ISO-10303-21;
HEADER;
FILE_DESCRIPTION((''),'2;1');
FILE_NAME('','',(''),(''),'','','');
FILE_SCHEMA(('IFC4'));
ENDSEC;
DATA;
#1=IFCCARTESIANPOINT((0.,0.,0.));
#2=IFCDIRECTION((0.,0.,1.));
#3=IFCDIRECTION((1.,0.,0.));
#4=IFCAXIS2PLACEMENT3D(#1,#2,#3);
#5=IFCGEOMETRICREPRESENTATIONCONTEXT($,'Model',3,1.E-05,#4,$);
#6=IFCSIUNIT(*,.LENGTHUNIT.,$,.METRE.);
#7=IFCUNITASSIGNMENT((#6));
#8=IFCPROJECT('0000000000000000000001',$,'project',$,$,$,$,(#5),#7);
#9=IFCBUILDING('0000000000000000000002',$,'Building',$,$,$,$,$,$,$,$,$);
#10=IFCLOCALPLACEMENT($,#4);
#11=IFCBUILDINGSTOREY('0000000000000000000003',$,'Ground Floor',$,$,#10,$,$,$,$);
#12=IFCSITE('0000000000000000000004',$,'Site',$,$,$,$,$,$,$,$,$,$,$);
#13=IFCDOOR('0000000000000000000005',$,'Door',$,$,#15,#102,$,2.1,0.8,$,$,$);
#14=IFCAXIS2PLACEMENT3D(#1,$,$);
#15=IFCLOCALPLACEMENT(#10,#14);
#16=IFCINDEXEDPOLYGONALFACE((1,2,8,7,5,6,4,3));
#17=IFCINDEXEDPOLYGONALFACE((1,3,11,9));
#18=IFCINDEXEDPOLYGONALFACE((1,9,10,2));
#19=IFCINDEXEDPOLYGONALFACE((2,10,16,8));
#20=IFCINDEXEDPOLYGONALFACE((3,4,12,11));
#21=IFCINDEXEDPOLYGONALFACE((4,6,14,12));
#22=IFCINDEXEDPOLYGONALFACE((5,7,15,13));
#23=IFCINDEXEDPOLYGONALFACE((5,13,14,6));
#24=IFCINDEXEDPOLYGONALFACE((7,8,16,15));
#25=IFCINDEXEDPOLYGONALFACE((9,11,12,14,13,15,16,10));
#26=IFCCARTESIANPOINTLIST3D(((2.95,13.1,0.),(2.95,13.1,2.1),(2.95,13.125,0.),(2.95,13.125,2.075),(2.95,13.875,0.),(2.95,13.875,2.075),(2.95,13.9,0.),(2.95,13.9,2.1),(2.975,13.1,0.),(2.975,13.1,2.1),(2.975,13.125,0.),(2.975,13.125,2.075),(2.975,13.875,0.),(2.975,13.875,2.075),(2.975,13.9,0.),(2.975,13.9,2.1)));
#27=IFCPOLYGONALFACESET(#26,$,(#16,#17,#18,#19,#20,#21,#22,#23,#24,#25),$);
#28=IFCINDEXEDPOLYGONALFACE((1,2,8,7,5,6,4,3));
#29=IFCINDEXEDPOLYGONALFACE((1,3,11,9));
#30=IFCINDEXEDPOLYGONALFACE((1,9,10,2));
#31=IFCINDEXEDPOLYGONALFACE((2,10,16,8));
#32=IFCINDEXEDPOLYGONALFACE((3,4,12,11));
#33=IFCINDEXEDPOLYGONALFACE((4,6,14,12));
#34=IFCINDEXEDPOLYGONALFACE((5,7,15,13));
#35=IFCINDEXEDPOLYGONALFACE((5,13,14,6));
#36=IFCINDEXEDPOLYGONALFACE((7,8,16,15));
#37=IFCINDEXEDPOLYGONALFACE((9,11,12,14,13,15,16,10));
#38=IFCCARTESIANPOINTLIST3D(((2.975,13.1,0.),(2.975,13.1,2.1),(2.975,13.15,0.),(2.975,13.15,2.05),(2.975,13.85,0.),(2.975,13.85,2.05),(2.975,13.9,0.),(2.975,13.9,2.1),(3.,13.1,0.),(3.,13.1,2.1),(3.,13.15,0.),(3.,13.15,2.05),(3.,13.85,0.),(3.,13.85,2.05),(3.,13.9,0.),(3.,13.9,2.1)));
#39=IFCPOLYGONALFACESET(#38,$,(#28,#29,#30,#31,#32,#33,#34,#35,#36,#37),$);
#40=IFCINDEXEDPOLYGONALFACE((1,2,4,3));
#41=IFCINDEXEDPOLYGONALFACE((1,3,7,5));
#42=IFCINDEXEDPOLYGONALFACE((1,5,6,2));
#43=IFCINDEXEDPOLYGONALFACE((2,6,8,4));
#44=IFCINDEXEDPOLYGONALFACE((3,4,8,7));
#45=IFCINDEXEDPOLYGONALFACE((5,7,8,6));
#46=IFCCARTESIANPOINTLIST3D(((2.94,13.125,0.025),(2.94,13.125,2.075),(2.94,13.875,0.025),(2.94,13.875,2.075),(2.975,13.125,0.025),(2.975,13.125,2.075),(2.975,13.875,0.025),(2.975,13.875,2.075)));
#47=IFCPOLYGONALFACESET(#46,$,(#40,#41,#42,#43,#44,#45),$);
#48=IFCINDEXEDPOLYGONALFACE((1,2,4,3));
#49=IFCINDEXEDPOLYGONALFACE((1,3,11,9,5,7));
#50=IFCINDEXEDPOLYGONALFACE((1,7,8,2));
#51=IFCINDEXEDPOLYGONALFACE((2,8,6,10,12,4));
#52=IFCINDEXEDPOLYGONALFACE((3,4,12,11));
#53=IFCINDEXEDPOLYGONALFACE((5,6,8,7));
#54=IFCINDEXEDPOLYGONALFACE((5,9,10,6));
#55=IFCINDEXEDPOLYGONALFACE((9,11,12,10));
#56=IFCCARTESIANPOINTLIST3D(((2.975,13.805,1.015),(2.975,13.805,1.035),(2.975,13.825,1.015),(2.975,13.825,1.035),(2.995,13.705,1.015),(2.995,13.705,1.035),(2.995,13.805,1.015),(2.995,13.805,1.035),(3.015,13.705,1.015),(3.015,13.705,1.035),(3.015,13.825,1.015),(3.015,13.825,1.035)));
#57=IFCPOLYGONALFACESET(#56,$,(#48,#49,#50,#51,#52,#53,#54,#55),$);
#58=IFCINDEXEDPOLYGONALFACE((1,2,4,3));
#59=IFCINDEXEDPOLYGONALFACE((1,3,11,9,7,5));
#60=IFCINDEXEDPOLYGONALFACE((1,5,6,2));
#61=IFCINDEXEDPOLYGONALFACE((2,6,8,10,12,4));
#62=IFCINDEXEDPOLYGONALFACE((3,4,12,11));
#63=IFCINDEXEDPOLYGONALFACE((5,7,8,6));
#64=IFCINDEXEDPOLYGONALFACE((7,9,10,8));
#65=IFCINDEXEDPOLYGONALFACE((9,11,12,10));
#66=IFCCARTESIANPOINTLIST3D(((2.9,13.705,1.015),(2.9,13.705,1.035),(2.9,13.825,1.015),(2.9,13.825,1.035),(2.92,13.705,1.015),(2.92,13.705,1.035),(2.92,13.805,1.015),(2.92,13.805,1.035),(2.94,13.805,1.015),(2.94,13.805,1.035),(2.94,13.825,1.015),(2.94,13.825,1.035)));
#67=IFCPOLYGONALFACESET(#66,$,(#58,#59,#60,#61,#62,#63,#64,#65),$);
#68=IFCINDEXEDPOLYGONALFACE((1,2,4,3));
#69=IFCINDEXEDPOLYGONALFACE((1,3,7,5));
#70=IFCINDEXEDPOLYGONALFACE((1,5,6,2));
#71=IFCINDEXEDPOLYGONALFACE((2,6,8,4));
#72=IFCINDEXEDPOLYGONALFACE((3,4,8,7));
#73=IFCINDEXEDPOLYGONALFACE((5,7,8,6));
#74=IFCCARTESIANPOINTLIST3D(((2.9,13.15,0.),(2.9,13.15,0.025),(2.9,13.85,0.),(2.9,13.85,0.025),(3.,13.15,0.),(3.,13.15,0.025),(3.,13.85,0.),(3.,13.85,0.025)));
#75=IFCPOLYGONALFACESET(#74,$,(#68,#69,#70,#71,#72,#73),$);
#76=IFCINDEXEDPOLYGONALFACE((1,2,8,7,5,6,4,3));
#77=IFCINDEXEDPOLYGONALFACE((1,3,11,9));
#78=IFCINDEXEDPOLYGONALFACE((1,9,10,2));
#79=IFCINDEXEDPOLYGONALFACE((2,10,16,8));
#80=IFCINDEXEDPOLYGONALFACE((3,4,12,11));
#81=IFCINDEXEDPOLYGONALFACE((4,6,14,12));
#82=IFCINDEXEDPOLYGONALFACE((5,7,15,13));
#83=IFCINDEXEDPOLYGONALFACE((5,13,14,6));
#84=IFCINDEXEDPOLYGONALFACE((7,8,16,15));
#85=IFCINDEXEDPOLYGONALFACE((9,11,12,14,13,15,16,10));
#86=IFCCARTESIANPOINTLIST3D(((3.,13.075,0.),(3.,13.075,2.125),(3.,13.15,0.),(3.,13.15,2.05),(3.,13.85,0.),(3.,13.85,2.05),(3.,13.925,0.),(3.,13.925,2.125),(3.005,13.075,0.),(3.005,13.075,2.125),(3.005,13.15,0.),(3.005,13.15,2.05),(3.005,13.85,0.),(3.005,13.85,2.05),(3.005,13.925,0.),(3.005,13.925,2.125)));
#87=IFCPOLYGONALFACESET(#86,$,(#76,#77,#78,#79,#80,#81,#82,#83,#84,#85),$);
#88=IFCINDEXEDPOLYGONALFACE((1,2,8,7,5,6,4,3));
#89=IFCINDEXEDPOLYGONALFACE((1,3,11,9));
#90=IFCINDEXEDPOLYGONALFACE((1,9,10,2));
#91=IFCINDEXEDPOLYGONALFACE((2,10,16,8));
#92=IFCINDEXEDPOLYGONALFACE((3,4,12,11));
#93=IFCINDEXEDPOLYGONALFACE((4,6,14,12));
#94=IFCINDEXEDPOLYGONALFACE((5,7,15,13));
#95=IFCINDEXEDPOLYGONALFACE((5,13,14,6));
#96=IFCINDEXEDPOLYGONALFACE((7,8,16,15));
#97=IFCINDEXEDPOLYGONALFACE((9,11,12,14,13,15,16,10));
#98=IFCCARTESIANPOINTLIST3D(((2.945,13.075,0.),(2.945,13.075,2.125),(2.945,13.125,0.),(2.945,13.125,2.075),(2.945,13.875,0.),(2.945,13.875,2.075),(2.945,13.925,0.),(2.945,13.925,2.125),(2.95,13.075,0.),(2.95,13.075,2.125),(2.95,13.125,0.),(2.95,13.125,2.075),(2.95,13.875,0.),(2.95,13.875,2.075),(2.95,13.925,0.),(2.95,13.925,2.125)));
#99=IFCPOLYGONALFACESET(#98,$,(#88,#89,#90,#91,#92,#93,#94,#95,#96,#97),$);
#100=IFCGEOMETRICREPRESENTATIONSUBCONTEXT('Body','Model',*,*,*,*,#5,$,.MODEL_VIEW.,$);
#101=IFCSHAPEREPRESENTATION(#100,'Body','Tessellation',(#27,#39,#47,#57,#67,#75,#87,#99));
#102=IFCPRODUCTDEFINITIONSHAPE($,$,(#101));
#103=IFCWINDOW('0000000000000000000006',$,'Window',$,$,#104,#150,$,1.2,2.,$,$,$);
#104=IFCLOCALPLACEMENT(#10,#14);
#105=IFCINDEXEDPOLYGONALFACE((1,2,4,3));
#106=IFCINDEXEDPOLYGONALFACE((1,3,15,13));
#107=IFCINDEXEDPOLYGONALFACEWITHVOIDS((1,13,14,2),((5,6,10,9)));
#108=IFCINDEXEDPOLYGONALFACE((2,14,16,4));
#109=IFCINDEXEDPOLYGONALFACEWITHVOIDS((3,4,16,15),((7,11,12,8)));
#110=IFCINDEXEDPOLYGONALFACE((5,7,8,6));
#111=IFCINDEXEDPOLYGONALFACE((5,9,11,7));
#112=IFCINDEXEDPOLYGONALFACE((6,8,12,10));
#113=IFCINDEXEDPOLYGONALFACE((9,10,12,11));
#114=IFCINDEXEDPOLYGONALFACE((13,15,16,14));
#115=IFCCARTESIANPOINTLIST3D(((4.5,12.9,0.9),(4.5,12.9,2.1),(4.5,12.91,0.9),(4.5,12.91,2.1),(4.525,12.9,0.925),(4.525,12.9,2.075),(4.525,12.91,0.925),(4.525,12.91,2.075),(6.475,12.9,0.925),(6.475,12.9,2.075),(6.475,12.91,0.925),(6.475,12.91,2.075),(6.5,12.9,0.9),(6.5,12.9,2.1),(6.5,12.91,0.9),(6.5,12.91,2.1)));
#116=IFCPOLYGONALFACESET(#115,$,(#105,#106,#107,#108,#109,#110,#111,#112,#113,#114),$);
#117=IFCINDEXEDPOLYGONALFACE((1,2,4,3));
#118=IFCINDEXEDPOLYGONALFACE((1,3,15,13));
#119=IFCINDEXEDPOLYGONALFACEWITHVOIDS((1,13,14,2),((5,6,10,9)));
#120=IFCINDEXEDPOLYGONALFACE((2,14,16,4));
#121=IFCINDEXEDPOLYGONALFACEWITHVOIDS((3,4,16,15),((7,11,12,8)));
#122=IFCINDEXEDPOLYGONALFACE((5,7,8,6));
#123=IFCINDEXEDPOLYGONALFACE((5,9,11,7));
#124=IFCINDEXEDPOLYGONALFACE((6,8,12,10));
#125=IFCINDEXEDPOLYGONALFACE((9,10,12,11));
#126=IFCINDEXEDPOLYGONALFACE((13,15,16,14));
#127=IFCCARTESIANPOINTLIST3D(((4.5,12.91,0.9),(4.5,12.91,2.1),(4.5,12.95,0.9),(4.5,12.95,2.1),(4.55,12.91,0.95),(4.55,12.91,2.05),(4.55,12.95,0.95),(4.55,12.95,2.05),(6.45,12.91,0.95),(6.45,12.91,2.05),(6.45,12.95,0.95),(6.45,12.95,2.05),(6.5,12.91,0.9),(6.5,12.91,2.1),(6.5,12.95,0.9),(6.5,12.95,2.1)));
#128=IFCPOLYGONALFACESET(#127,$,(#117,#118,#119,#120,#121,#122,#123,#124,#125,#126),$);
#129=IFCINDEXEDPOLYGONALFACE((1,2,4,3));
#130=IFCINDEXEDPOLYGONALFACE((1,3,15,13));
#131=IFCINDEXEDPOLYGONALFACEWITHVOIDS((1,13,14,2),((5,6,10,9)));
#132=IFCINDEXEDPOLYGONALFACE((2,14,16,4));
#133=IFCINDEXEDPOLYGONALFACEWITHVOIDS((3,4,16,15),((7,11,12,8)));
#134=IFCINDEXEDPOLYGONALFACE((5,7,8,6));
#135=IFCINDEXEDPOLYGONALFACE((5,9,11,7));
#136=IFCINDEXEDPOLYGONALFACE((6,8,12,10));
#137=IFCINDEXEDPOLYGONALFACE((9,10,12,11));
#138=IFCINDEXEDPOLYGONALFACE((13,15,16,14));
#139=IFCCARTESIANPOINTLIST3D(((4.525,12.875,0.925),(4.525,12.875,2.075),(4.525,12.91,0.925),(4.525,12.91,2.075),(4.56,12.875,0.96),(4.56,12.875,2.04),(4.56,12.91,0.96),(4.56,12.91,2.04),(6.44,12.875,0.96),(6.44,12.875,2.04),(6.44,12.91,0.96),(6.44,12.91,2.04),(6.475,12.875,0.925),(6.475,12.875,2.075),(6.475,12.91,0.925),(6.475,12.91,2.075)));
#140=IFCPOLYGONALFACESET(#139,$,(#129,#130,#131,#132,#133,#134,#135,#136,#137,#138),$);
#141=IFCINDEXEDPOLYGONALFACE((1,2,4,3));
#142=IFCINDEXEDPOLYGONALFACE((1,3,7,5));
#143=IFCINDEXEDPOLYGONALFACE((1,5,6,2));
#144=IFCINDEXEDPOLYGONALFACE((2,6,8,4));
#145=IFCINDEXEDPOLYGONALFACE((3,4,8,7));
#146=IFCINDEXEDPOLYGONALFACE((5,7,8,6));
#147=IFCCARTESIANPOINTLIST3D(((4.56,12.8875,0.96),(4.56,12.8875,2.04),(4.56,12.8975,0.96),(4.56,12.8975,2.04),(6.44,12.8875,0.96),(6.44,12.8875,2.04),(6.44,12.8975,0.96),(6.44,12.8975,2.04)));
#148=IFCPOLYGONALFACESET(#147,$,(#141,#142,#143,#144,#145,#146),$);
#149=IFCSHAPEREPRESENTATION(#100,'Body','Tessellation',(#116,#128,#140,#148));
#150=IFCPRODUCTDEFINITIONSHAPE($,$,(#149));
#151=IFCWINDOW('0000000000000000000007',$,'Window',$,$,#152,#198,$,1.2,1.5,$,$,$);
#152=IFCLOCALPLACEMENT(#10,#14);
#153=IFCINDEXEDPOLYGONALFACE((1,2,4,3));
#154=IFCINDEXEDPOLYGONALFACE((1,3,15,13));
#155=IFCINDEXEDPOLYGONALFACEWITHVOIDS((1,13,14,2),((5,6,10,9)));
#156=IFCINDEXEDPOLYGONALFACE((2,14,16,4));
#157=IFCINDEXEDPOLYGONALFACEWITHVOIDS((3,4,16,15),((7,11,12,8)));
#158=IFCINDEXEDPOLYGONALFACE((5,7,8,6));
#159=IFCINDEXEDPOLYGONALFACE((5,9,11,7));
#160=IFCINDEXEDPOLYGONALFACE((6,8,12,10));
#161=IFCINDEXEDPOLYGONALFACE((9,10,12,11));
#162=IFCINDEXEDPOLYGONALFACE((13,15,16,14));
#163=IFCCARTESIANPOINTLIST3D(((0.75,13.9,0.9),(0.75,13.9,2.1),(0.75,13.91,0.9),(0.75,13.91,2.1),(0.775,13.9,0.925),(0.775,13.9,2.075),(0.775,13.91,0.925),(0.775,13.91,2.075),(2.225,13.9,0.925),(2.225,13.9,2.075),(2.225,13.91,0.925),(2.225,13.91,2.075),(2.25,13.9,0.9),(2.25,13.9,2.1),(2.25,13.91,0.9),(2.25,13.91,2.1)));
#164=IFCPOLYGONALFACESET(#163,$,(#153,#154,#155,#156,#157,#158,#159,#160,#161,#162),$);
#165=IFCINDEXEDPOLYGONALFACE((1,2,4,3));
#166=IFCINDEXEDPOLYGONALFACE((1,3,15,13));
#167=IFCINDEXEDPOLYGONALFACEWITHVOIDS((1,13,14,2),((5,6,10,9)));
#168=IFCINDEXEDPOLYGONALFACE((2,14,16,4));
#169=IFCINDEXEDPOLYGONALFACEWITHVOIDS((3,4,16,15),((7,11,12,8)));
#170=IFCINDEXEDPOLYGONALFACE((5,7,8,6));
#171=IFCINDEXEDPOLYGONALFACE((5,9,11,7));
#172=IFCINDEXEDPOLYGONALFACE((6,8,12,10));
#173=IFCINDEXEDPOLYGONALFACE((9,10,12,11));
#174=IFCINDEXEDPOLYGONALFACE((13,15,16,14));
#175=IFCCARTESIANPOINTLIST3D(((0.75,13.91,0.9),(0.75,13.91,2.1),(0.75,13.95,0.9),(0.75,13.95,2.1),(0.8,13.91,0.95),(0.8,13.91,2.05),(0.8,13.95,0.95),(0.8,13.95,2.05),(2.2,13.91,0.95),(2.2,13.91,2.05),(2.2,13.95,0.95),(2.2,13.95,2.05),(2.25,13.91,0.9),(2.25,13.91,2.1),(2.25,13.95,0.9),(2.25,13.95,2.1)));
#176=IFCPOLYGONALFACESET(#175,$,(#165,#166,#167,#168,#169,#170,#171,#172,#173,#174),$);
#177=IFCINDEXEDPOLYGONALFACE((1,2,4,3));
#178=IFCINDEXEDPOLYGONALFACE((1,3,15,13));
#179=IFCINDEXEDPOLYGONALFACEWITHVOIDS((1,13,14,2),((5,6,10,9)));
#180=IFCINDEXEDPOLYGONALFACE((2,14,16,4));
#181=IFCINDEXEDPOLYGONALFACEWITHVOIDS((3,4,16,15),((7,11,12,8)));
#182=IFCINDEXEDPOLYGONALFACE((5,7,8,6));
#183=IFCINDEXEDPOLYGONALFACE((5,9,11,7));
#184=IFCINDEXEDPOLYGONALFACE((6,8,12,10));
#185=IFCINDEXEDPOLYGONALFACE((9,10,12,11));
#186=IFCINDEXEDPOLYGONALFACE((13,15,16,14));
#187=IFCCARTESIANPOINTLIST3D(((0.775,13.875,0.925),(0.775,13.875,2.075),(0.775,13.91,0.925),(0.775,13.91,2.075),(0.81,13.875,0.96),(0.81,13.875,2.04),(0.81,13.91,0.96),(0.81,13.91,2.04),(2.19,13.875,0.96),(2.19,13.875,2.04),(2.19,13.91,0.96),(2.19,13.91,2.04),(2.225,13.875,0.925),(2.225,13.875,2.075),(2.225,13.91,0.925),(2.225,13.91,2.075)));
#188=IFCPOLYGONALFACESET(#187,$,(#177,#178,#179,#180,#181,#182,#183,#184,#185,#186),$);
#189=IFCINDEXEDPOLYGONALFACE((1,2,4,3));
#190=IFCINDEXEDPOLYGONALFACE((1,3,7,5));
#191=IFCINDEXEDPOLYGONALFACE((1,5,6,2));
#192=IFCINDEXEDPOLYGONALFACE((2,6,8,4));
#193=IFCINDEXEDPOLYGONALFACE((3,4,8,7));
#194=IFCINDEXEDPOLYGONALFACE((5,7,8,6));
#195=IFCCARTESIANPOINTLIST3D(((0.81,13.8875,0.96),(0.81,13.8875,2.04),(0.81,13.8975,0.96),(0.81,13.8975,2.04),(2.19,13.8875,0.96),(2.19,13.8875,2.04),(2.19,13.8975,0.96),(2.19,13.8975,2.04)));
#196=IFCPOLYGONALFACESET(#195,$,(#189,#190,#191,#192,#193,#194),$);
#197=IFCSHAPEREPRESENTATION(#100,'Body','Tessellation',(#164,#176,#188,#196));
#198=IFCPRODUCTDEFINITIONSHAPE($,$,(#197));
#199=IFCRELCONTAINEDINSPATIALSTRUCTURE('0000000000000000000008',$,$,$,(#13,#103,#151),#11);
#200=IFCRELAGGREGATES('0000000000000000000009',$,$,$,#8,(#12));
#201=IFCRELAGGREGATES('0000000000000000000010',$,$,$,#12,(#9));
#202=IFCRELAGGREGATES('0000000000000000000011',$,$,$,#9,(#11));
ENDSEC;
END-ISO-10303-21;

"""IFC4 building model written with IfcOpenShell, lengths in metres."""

from ifc_helpers import new_model, si_unit, frame, origin_with_axes, place, context, subcontext, project, spatial, line, indexed_curve, outline, extrude, element, save


model = new_model("IFC4")

# Units and contexts
model_context = context("Model", 3, precision=1e-05, world=origin_with_axes())
body_context = subcontext(model_context, "Body", "Model", "MODEL_VIEW")
ifc_project = project(units=[si_unit("LENGTHUNIT", "METRE")], contexts=[model_context])

# Site, building, storey
site = spatial("IfcSite", under=ifc_project, Name="Site")
building = spatial("IfcBuilding", under=site, Name="Building")
storey_placement = place(None, origin_with_axes())
storey = spatial("IfcBuildingStorey", under=building, at=storey_placement, Name="Ground Floor")

# Door
door_1_placement = place(storey_placement, frame((3.0, 13.1, 0.0), z_axis=(0.0, 0.0, 1.0), x_axis=(0.0, 1.0, 0.0)))
element("IfcDoor", 1, at=door_1_placement, inside=storey, Name="Door", OverallHeight=2.1, OverallWidth=0.8, context=body_context, shape_type="SweptSolid", body=[
    extrude(outline(indexed_curve([(0.0, 0.0), (0.0, 2.1), (0.8, 2.1), (0.8, 0.0), (0.775, 0.0), (0.775, 2.075), (0.025, 2.075), (0.025, 0.0)], segments=[line(1, 2, 3, 4, 5, 6, 7, 8, 1)])), frame((0.0, 0.025, 0.0), z_axis=(0.0, -1.0, 0.0), x_axis=(1.0, 0.0, 0.0)), (0.0, 0.0, -1.0), 0.025),
    extrude(outline(indexed_curve([(0.0, 0.0), (0.0, 2.1), (0.8, 2.1), (0.8, 0.0), (0.75, 0.0), (0.75, 2.05), (0.05, 2.05), (0.05, 0.0)], segments=[line(1, 2, 3, 4, 5, 6, 7, 8, 1)])), frame((0.0, 0.0, 0.0), z_axis=(0.0, -1.0, 0.0), x_axis=(1.0, 0.0, 0.0)), (0.0, 0.0, -1.0), 0.025),
    extrude(outline(indexed_curve([(0.0, 0.0), (0.75, 0.0), (0.75, 0.035), (0.0, 0.035)], segments=[line(1, 2, 3, 4, 1)])), frame((0.025, 0.025, 0.025), z_axis=(0.0, 0.0, 1.0), x_axis=(1.0, 0.0, 0.0)), (0.0, 0.0, 1.0), 2.05),
    extrude(outline(indexed_curve([(0.0, 0.0), (0.0, -0.04), (-0.12, -0.04), (-0.12, -0.02), (-0.02, -0.02), (-0.02, 0.0)], segments=[line(1, 2, 3, 4, 5, 6, 1)])), frame((0.725, 0.025, 1.015), z_axis=(0.0, 0.0, 1.0), x_axis=(1.0, 0.0, 0.0)), (0.0, 0.0, 1.0), 0.02),
    extrude(outline(indexed_curve([(0.0, 0.0), (0.0, 0.04), (-0.12, 0.04), (-0.12, 0.02), (-0.02, 0.02), (-0.02, 0.0)], segments=[line(1, 2, 3, 4, 5, 6, 1)])), frame((0.725, 0.06, 1.015), z_axis=(0.0, 0.0, 1.0), x_axis=(1.0, 0.0, 0.0)), (0.0, 0.0, 1.0), 0.02),
    extrude(outline(indexed_curve([(0.0, 0.0), (0.7, 0.0), (0.7, 0.1), (0.0, 0.1)], segments=[line(1, 2, 3, 4, 1)])), frame((0.05, 0.0, 0.0), z_axis=(0.0, 0.0, 1.0), x_axis=(1.0, 0.0, 0.0)), (0.0, 0.0, 1.0), 0.025),
    extrude(outline(indexed_curve([(0.0, 0.0), (0.0, 2.125), (0.85, 2.125), (0.85, 0.0), (0.775, 0.0), (0.775, 2.05), (0.075, 2.05), (0.075, 0.0)], segments=[line(1, 2, 3, 4, 5, 6, 7, 8, 1)])), frame((-0.025, -0.005, 0.0), z_axis=(0.0, -1.0, 0.0), x_axis=(1.0, 0.0, 0.0)), (0.0, 0.0, -1.0), 0.005),
    extrude(outline(indexed_curve([(0.0, 0.0), (0.0, 2.125), (0.85, 2.125), (0.85, 0.0), (0.8, 0.0), (0.8, 2.075), (0.05, 2.075), (0.05, 0.0)], segments=[line(1, 2, 3, 4, 5, 6, 7, 8, 1)])), frame((-0.025, 0.05, 0.0), z_axis=(0.0, -1.0, 0.0), x_axis=(1.0, 0.0, 0.0)), (0.0, 0.0, -1.0), 0.005),
])

# Windows
window_1_placement = place(storey_placement, frame((6.5, 13.0, 0.9), z_axis=(0.0, 0.0, 1.0), x_axis=(-1.0, 0.0, 0.0)))
element("IfcWindow", 2, at=window_1_placement, inside=storey, Name="Window", OverallHeight=1.2, OverallWidth=2.0, context=body_context, shape_type="SweptSolid", body=[
    extrude(outline(indexed_curve([(0.0, 0.0), (2.0, 0.0), (2.0, 1.2), (0.0, 1.2)], segments=[line(1, 2, 3, 4, 1)]), holes=[indexed_curve([(0.025, 0.025), (1.975, 0.025), (1.975, 1.175), (0.025, 1.175)], segments=[line(1, 2, 3, 4, 1)])]), frame((0.0, 0.09, 0.0), z_axis=(0.0, -1.0, 0.0), x_axis=(1.0, 0.0, 0.0)), (0.0, 0.0, -1.0), 0.01),
    extrude(outline(indexed_curve([(0.0, 0.0), (2.0, 0.0), (2.0, 1.2), (0.0, 1.2)], segments=[line(1, 2, 3, 4, 1)]), holes=[indexed_curve([(0.05, 0.05), (1.95, 0.05), (1.95, 1.15), (0.05, 1.15)], segments=[line(1, 2, 3, 4, 1)])]), frame((0.0, 0.05, 0.0), z_axis=(0.0, -1.0, 0.0), x_axis=(1.0, 0.0, 0.0)), (0.0, 0.0, -1.0), 0.04),
    extrude(outline(indexed_curve([(0.0, 0.0), (1.95, 0.0), (1.95, 1.15), (0.0, 1.15)], segments=[line(1, 2, 3, 4, 1)]), holes=[indexed_curve([(0.035, 0.035), (1.915, 0.035), (1.915, 1.115), (0.035, 1.115)], segments=[line(1, 2, 3, 4, 1)])]), frame((0.025, 0.09, 0.025), z_axis=(0.0, -1.0, 0.0), x_axis=(1.0, 0.0, 0.0)), (0.0, 0.0, -1.0), 0.035),
    extrude(outline(indexed_curve([(0.035, 0.035), (1.915, 0.035), (1.915, 1.115), (0.035, 1.115)], segments=[line(1, 2, 3, 4, 1)])), frame((0.025, 0.1025, 0.025), z_axis=(0.0, -1.0, 0.0), x_axis=(1.0, 0.0, 0.0)), (0.0, 0.0, -1.0), 0.01),
])
window_2_placement = place(storey_placement, frame((2.25, 14.0, 0.9), z_axis=(0.0, 0.0, 1.0), x_axis=(-1.0, 0.0, 0.0)))
element("IfcWindow", 3, at=window_2_placement, inside=storey, Name="Window", OverallHeight=1.2, OverallWidth=1.5, context=body_context, shape_type="SweptSolid", body=[
    extrude(outline(indexed_curve([(0.0, 0.0), (1.5, 0.0), (1.5, 1.2), (0.0, 1.2)], segments=[line(1, 2, 3, 4, 1)]), holes=[indexed_curve([(0.025, 0.025), (1.475, 0.025), (1.475, 1.175), (0.025, 1.175)], segments=[line(1, 2, 3, 4, 1)])]), frame((0.0, 0.09, 0.0), z_axis=(0.0, -1.0, 0.0), x_axis=(1.0, 0.0, 0.0)), (0.0, 0.0, -1.0), 0.01),
    extrude(outline(indexed_curve([(0.0, 0.0), (1.5, 0.0), (1.5, 1.2), (0.0, 1.2)], segments=[line(1, 2, 3, 4, 1)]), holes=[indexed_curve([(0.05, 0.05), (1.45, 0.05), (1.45, 1.15), (0.05, 1.15)], segments=[line(1, 2, 3, 4, 1)])]), frame((0.0, 0.05, 0.0), z_axis=(0.0, -1.0, 0.0), x_axis=(1.0, 0.0, 0.0)), (0.0, 0.0, -1.0), 0.04),
    extrude(outline(indexed_curve([(0.0, 0.0), (1.45, 0.0), (1.45, 1.15), (0.0, 1.15)], segments=[line(1, 2, 3, 4, 1)]), holes=[indexed_curve([(0.035, 0.035), (1.415, 0.035), (1.415, 1.115), (0.035, 1.115)], segments=[line(1, 2, 3, 4, 1)])]), frame((0.025, 0.09, 0.025), z_axis=(0.0, -1.0, 0.0), x_axis=(1.0, 0.0, 0.0)), (0.0, 0.0, -1.0), 0.035),
    extrude(outline(indexed_curve([(0.035, 0.035), (1.415, 0.035), (1.415, 1.115), (0.035, 1.115)], segments=[line(1, 2, 3, 4, 1)])), frame((0.025, 0.1025, 0.025), z_axis=(0.0, -1.0, 0.0), x_axis=(1.0, 0.0, 0.0)), (0.0, 0.0, -1.0), 0.01),
])

save(model, "model.ifc")
